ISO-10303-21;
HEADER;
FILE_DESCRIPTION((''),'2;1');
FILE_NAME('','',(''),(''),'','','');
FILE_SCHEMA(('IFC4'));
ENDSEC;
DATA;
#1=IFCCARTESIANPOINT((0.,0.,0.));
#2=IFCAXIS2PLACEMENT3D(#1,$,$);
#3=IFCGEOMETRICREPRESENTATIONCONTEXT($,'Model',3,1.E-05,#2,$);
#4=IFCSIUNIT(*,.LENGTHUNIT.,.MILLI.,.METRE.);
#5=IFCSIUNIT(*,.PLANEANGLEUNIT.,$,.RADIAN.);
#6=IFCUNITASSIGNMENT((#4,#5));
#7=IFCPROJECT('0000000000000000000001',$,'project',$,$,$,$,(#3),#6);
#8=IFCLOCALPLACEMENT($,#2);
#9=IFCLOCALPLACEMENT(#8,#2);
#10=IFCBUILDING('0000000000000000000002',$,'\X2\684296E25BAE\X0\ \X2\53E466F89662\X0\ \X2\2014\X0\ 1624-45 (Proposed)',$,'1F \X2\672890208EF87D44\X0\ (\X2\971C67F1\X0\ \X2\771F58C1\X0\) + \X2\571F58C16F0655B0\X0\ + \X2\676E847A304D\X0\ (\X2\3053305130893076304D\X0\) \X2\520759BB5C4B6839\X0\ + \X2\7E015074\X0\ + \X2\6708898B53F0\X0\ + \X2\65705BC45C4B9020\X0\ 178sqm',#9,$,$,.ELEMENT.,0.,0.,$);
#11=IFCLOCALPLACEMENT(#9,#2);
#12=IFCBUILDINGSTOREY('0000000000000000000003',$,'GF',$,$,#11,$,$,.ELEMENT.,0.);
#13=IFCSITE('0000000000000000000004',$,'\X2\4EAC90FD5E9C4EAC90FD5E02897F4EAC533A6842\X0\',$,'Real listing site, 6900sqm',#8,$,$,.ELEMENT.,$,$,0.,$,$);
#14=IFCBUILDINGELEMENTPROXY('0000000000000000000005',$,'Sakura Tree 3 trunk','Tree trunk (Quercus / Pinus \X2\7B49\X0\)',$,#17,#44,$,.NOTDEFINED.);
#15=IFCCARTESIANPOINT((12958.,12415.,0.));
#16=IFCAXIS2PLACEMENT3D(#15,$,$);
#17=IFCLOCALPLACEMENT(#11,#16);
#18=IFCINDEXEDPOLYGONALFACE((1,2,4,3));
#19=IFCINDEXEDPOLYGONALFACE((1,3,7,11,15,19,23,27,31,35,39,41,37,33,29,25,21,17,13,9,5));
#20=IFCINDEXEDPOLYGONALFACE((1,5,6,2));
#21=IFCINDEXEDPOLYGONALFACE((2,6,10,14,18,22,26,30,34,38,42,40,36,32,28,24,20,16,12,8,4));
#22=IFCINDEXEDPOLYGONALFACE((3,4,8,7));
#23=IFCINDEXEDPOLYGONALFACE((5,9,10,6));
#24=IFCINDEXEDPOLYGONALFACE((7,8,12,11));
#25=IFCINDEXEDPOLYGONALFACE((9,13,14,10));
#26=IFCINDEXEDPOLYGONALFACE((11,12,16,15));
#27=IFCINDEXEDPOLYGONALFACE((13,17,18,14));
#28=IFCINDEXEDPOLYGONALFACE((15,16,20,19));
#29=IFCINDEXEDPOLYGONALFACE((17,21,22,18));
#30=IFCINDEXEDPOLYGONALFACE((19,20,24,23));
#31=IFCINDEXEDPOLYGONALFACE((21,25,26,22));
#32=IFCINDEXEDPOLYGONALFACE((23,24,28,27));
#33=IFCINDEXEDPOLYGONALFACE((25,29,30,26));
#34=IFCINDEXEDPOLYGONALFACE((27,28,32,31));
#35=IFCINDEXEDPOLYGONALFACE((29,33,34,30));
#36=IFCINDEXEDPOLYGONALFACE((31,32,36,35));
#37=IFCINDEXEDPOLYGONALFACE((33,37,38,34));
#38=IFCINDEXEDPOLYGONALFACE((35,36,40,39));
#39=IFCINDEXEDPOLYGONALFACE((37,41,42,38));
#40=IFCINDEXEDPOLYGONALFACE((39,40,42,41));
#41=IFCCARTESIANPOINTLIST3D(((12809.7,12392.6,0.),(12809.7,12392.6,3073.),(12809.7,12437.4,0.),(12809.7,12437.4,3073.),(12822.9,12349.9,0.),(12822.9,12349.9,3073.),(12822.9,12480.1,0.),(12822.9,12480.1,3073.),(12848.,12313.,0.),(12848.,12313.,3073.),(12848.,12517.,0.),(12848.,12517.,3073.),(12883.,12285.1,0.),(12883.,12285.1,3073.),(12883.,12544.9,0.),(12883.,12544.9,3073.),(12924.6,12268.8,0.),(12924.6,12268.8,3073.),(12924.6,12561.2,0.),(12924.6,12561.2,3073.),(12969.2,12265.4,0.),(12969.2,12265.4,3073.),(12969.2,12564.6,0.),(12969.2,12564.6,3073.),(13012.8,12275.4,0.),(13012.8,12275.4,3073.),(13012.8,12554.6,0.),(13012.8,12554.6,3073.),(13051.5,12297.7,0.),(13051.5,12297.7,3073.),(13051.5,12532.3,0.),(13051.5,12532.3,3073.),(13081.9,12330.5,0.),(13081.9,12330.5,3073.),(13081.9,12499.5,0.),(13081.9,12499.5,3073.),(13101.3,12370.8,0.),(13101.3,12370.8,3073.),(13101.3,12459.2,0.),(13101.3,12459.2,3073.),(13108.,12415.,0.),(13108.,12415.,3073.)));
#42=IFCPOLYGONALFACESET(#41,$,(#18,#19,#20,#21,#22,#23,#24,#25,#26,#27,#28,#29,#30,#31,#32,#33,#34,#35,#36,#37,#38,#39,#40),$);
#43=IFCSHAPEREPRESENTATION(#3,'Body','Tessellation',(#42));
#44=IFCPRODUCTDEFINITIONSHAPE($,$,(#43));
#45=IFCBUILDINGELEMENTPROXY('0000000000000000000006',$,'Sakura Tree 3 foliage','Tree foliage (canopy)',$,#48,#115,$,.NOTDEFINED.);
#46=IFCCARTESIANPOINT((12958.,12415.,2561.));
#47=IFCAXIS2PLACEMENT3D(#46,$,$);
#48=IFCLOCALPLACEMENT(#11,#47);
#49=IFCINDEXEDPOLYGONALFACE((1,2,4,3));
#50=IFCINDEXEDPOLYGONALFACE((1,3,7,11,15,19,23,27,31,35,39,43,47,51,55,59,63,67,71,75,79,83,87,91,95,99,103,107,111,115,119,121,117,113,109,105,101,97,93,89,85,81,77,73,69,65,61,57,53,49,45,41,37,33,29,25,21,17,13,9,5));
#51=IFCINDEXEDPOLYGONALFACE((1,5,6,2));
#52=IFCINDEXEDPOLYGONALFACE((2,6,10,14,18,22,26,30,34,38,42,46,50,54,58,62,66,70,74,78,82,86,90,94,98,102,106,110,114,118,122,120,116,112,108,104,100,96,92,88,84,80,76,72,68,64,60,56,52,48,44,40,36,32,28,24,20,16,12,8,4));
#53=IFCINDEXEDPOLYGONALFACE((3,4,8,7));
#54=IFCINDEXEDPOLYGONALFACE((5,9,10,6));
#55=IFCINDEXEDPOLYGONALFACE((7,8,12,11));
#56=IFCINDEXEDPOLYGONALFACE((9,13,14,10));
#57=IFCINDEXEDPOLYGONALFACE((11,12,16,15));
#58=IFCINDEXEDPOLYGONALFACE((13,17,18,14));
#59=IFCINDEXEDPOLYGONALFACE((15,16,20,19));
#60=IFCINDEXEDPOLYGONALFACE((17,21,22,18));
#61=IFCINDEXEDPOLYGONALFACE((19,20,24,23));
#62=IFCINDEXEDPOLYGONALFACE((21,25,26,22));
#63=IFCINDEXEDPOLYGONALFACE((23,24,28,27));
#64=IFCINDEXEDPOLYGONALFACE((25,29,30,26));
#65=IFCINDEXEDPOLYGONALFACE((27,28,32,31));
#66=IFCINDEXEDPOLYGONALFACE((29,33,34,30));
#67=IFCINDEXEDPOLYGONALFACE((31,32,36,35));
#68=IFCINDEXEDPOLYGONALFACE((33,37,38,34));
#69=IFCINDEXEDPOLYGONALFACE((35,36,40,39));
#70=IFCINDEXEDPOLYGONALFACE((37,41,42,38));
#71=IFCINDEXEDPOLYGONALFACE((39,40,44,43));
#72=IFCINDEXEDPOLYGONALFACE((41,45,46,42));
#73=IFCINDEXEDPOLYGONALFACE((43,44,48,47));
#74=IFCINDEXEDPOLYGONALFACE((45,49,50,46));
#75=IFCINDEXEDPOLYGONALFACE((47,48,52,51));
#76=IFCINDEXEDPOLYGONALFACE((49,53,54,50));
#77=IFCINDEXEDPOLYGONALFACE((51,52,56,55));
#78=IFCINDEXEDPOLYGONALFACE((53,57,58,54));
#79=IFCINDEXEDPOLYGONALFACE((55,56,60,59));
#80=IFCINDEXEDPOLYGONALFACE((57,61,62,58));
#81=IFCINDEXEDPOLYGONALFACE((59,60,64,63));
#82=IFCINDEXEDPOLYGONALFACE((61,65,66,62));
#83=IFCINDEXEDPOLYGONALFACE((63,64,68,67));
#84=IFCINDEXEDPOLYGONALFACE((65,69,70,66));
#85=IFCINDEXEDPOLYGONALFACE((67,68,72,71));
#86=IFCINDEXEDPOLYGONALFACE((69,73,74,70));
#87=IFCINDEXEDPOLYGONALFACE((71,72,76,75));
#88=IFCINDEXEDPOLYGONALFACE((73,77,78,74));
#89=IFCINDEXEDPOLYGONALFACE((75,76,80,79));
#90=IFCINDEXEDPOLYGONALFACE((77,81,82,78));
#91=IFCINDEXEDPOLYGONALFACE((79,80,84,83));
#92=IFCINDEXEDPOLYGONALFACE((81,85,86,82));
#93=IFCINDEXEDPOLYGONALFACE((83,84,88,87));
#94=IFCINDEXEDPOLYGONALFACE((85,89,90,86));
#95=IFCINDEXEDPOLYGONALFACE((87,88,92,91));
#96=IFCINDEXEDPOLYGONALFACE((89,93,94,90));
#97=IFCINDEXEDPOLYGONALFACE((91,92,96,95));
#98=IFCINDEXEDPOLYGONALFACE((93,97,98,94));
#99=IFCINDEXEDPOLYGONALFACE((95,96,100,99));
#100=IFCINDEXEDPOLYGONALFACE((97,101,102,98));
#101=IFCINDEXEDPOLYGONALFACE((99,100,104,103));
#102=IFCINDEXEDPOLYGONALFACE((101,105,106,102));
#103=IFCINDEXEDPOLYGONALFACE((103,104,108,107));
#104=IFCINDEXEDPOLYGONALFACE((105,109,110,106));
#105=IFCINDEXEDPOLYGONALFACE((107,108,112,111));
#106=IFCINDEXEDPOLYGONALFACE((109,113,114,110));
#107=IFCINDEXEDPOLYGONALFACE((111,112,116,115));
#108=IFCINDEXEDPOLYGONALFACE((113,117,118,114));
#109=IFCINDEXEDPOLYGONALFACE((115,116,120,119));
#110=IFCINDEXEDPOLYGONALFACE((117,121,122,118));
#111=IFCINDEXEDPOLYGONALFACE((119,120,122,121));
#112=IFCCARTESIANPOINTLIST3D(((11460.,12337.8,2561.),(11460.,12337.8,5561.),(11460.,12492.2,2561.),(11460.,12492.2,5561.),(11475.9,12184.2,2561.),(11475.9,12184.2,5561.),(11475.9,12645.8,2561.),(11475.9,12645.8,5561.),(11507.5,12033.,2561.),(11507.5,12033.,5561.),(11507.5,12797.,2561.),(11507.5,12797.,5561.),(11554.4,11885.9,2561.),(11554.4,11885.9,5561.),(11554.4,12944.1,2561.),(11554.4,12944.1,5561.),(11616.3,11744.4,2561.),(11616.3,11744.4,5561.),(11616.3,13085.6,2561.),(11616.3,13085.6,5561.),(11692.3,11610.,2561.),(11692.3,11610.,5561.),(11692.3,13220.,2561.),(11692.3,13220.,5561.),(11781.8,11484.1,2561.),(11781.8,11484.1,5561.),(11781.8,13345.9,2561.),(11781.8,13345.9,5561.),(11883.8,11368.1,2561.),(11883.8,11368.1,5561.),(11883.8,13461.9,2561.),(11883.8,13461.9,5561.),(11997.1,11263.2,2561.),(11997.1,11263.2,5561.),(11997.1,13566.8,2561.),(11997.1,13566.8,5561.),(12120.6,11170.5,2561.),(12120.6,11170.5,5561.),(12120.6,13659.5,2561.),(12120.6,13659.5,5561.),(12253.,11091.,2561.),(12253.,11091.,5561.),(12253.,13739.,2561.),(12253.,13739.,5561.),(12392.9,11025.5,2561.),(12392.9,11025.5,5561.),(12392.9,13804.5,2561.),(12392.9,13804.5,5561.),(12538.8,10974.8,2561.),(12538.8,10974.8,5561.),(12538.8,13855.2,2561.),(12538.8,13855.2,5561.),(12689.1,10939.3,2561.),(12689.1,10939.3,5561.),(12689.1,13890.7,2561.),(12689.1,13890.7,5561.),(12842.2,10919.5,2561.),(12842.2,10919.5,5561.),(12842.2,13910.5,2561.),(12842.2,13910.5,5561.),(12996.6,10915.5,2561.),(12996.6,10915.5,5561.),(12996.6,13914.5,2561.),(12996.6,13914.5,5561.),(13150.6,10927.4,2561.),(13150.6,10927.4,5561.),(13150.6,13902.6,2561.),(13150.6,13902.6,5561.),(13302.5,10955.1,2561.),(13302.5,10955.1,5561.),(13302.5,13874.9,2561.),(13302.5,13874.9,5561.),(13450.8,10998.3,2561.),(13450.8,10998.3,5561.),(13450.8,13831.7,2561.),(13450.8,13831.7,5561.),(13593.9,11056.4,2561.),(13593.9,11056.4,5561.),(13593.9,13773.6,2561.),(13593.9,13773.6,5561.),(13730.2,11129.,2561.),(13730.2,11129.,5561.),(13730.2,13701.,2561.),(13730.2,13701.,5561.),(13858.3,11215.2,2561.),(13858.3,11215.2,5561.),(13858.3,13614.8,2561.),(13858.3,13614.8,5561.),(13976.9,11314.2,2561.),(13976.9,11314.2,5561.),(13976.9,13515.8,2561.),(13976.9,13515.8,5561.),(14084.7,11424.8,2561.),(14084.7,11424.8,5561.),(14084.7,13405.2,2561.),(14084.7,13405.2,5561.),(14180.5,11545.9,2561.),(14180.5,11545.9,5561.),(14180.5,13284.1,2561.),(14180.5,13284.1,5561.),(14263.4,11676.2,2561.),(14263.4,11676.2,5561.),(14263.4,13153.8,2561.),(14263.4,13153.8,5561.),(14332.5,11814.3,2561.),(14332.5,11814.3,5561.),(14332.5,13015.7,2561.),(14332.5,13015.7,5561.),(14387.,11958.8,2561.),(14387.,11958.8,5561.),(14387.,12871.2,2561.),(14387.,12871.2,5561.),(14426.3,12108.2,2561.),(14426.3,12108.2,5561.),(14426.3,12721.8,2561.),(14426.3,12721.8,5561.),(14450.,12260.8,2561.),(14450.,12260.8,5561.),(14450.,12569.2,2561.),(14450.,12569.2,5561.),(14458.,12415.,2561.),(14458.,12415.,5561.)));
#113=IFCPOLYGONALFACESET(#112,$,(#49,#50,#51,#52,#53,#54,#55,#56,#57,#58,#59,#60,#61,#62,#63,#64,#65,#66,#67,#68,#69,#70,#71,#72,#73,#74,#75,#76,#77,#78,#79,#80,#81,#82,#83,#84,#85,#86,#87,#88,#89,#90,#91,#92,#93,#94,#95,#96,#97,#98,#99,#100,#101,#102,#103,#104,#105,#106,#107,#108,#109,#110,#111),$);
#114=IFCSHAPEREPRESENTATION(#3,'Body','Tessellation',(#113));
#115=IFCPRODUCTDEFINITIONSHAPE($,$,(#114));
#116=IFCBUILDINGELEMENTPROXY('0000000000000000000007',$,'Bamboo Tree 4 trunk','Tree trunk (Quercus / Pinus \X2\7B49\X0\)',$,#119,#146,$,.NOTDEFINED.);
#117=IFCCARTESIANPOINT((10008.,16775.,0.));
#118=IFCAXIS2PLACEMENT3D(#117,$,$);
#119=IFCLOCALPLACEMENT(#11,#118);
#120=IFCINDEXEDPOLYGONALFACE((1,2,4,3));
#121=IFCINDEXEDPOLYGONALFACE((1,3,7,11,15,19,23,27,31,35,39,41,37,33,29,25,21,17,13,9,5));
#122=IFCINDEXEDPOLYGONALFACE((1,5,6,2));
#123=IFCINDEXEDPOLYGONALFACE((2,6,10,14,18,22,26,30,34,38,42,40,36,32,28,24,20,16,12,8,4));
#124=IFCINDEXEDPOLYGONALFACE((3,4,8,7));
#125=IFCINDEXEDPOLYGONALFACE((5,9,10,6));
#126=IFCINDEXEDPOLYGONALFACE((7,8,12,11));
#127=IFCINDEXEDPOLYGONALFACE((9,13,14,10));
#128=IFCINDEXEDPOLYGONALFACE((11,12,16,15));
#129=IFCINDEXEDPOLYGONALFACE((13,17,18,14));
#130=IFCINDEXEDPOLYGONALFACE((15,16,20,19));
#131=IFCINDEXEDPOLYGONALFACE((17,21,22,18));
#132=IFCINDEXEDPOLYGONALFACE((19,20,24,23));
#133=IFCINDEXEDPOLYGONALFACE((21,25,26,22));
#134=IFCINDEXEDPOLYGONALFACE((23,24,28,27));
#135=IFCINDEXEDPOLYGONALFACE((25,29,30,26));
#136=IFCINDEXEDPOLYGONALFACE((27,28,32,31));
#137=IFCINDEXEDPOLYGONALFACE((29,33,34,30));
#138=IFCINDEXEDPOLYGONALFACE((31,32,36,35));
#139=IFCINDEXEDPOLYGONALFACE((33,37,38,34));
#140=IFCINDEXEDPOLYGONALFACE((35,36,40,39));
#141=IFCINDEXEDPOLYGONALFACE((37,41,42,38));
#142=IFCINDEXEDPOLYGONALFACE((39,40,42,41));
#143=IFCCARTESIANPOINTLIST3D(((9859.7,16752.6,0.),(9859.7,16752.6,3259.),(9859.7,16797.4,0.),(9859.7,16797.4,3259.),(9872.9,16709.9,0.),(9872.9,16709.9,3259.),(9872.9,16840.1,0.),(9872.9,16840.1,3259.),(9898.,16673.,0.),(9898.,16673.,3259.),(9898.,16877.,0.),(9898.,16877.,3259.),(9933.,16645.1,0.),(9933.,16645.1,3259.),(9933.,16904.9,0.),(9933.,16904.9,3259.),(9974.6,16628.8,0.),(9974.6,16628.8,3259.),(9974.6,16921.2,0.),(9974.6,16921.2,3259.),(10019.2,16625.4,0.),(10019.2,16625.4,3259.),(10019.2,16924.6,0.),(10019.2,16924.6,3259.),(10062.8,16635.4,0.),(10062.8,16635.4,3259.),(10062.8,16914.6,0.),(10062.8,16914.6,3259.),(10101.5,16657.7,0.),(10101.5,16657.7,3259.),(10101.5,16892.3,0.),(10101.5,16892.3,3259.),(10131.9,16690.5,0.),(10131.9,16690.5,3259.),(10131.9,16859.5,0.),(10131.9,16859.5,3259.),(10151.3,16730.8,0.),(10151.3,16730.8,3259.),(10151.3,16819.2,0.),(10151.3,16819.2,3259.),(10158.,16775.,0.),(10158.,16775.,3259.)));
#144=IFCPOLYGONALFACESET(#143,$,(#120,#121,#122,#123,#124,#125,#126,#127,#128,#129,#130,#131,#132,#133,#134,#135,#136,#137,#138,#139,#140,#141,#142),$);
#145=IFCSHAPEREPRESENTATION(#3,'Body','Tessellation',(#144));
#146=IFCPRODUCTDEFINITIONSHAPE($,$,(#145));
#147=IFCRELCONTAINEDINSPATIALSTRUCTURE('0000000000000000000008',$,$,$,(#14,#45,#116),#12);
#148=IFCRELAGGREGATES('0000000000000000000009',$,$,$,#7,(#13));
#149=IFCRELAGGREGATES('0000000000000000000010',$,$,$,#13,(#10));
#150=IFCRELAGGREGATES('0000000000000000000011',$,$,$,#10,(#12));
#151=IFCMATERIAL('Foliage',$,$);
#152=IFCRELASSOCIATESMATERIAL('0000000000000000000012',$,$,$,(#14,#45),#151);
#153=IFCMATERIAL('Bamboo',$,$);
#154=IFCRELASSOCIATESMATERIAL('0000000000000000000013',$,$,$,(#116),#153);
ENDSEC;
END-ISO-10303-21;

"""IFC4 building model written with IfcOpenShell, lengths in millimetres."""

from ifc_helpers import new_model, si_unit, frame, origin, origin_2d, place, context, project, spatial, circle, extrude, material, element, save


model = new_model("IFC4")

# Units and contexts
model_context = context("Model", 3, precision=1e-05, world=origin())
ifc_project = project(units=[si_unit("LENGTHUNIT", "METRE", prefix="MILLI"), si_unit("PLANEANGLEUNIT", "RADIAN")], contexts=[model_context])

# Site, building, storey
site_placement = place(None, origin())
site = spatial("IfcSite", under=ifc_project, at=site_placement, Name="京都府京都市西京区桂", ObjectType="Real listing site, 6900sqm", CompositionType="ELEMENT", RefElevation=0.0)
building_placement = place(site_placement, origin())
building = spatial("IfcBuilding", under=site, at=building_placement, Name="桂離宮 古書院 — 1624-45 (Proposed)", ObjectType="1F 木造軸組 (霜柱 真壁) + 土壁漆喰 + 杮葺き (こけらぶき) 切妻屋根 + 縁側 + 月見台 + 数寄屋造 178sqm", CompositionType="ELEMENT", ElevationOfRefHeight=0.0, ElevationOfTerrain=0.0)
storey_placement = place(building_placement, origin())
storey = spatial("IfcBuildingStorey", under=building, at=storey_placement, Name="GF", CompositionType="ELEMENT", Elevation=0.0)

# Building element proxies
ifc_material_1 = material(Name="Foliage")
proxy_1_placement = place(storey_placement, frame((12958.0, 12415.0, 0.0)))
element("IfcBuildingElementProxy", 1, at=proxy_1_placement, inside=storey, material=ifc_material_1, Name="Sakura Tree 3 trunk", Description="Tree trunk (Quercus / Pinus 等)", PredefinedType="NOTDEFINED", context=model_context, shape_type="SweptSolid", body=[
    extrude(circle(Radius=150.0, at=origin_2d()), frame((12958.0, 12415.0, 0.0)), (0.0, 0.0, 1.0), 3073.0),
])
proxy_2_placement = place(storey_placement, frame((12958.0, 12415.0, 2561.0)))
element("IfcBuildingElementProxy", 2, at=proxy_2_placement, inside=storey, material=ifc_material_1, Name="Sakura Tree 3 foliage", Description="Tree foliage (canopy)", PredefinedType="NOTDEFINED", context=model_context, shape_type="SweptSolid", body=[
    extrude(circle(Radius=1500.0, at=origin_2d()), frame((12958.0, 12415.0, 2561.0)), (0.0, 0.0, 1.0), 3000.0),
])
ifc_material_2 = material(Name="Bamboo")
proxy_3_placement = place(storey_placement, frame((10008.0, 16775.0, 0.0)))
element("IfcBuildingElementProxy", 3, at=proxy_3_placement, inside=storey, material=ifc_material_2, Name="Bamboo Tree 4 trunk", Description="Tree trunk (Quercus / Pinus 等)", PredefinedType="NOTDEFINED", context=model_context, shape_type="SweptSolid", body=[
    extrude(circle(Radius=150.0, at=origin_2d()), frame((10008.0, 16775.0, 0.0)), (0.0, 0.0, 1.0), 3259.0),
])

save(model, "model.ifc")
